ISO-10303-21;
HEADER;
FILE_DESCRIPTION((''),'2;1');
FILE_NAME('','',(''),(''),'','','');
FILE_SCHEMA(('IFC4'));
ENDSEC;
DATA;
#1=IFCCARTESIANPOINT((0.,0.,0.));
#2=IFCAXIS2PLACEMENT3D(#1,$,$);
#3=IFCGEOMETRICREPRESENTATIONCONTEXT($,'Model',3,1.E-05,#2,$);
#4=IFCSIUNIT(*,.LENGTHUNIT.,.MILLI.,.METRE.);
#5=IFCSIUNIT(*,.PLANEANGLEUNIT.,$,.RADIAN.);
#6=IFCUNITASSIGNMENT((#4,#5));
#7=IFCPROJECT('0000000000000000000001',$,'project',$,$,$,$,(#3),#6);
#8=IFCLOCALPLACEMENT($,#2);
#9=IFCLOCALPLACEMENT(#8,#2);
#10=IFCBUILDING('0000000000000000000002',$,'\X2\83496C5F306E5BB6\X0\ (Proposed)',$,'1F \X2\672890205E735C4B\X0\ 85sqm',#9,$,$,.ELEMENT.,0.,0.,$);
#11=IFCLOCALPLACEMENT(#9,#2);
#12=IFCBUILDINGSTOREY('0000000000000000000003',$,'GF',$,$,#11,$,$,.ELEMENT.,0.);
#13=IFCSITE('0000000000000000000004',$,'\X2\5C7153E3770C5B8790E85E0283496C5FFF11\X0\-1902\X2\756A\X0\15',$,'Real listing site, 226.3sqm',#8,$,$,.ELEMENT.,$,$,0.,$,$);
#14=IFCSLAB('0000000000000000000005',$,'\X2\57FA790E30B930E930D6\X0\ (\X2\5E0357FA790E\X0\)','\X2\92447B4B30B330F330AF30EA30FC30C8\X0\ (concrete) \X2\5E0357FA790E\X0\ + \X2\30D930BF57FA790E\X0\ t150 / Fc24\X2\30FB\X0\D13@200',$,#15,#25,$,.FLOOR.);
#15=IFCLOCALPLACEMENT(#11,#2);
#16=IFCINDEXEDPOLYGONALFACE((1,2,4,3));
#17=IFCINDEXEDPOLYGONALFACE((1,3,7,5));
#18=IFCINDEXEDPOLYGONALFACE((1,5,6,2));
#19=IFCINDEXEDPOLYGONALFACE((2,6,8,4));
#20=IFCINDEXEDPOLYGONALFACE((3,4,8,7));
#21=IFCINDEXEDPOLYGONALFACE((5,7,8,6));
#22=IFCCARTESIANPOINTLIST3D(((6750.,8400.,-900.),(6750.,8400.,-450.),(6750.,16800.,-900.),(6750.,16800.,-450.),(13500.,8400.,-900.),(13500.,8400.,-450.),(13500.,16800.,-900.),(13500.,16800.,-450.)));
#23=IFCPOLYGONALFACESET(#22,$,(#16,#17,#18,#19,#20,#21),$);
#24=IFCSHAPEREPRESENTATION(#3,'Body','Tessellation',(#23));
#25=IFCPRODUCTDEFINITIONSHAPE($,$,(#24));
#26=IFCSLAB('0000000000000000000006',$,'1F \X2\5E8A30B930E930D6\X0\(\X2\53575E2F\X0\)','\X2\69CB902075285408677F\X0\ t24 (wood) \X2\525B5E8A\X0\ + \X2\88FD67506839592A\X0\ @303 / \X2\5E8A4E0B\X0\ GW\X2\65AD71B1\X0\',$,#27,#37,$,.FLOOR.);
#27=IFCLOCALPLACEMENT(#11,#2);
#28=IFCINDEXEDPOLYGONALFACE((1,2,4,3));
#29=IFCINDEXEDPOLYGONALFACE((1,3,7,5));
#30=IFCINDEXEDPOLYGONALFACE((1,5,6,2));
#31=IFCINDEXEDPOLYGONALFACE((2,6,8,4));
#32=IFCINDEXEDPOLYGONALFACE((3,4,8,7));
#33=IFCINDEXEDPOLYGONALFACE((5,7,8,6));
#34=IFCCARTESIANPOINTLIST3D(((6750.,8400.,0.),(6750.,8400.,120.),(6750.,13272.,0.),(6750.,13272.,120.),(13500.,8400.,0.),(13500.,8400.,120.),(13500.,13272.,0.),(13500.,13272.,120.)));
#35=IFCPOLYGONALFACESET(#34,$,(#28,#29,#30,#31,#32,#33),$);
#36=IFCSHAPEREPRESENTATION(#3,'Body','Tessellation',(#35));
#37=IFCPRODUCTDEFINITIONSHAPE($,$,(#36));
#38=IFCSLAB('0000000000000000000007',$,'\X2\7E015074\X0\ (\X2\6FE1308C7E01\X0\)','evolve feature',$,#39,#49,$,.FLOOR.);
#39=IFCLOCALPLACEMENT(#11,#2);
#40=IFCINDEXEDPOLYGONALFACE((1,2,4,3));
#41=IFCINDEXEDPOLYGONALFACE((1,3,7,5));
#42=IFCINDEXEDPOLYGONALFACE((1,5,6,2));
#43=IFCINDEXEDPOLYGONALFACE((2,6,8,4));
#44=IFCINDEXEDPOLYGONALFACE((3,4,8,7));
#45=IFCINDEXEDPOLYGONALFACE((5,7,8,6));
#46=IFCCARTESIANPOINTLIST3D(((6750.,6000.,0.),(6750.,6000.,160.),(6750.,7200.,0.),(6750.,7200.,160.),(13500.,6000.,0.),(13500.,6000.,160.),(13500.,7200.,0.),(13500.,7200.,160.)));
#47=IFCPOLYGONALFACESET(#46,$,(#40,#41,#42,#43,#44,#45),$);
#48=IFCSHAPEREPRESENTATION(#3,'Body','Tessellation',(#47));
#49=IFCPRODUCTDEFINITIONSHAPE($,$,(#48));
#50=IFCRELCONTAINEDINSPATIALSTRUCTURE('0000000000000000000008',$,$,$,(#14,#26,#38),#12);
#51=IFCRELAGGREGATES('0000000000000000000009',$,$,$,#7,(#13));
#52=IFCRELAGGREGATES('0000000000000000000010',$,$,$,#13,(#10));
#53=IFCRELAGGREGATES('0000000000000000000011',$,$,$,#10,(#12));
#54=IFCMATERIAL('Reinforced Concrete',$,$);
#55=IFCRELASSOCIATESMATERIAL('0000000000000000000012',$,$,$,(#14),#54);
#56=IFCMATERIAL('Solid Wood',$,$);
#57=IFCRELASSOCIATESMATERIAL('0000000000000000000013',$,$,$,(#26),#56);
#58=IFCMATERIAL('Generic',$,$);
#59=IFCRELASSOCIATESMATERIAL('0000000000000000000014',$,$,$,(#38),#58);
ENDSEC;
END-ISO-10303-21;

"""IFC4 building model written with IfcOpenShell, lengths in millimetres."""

from ifc_helpers import new_model, si_unit, frame, frame_2d, origin, place, context, project, spatial, rectangle, extrude, material, element, save


model = new_model("IFC4")

# Units and contexts
model_context = context("Model", 3, precision=1e-05, world=origin())
ifc_project = project(units=[si_unit("LENGTHUNIT", "METRE", prefix="MILLI"), si_unit("PLANEANGLEUNIT", "RADIAN")], contexts=[model_context])

# Site, building, storey
site_placement = place(None, origin())
site = spatial("IfcSite", under=ifc_project, at=site_placement, Name="山口県宇部市草江１-1902番15", ObjectType="Real listing site, 226.3sqm", CompositionType="ELEMENT", RefElevation=0.0)
building_placement = place(site_placement, origin())
building = spatial("IfcBuilding", under=site, at=building_placement, Name="草江の家 (Proposed)", ObjectType="1F 木造平屋 85sqm", CompositionType="ELEMENT", ElevationOfRefHeight=0.0, ElevationOfTerrain=0.0)
storey_placement = place(building_placement, origin())
storey = spatial("IfcBuildingStorey", under=building, at=storey_placement, Name="GF", CompositionType="ELEMENT", Elevation=0.0)

# Slabs
ifc_material_1 = material(Name="Reinforced Concrete")
slab_1_placement = place(storey_placement, frame((3375.0, 4200.0, -450.0)))
element("IfcSlab", 1, at=slab_1_placement, inside=storey, material=ifc_material_1, Name="基礎スラブ (布基礎)", Description="鉄筋コンクリート (concrete) 布基礎 + ベタ基礎 t150 / Fc24・D13@200", PredefinedType="FLOOR", context=model_context, shape_type="SweptSolid", body=[
    extrude(rectangle(XDim=6750.0, YDim=8400.0, at=frame_2d((3375.0, 4200.0))), frame((3375.0, 4200.0, -450.0)), (0.0, 0.0, 1.0), 450.0),
])
ifc_material_2 = material(Name="Solid Wood")
slab_2_placement = place(storey_placement, frame((3375.0, 4200.0, 0.0)))
element("IfcSlab", 2, at=slab_2_placement, inside=storey, material=ifc_material_2, Name="1F 床スラブ(南帯)", Description="構造用合板 t24 (wood) 剛床 + 製材根太 @303 / 床下 GW断熱", PredefinedType="FLOOR", context=model_context, shape_type="SweptSolid", body=[
    extrude(rectangle(XDim=6750.0, YDim=4872.0, at=frame_2d((3375.0, 2436.0))), frame((3375.0, 4200.0, 0.0)), (0.0, 0.0, 1.0), 120.0),
])
ifc_material_3 = material(Name="Generic")
slab_3_placement = place(storey_placement, frame((3375.0, 3000.0, 0.0)))
element("IfcSlab", 3, at=slab_3_placement, inside=storey, material=ifc_material_3, Name="縁側 (濡れ縁)", Description="evolve feature", PredefinedType="FLOOR", context=model_context, shape_type="SweptSolid", body=[
    extrude(rectangle(XDim=6750.0, YDim=1200.0, at=frame_2d((3375.0, 600.0))), frame((3375.0, 3000.0, 0.0)), (0.0, 0.0, 1.0), 160.0),
])

save(model, "model.ifc")
